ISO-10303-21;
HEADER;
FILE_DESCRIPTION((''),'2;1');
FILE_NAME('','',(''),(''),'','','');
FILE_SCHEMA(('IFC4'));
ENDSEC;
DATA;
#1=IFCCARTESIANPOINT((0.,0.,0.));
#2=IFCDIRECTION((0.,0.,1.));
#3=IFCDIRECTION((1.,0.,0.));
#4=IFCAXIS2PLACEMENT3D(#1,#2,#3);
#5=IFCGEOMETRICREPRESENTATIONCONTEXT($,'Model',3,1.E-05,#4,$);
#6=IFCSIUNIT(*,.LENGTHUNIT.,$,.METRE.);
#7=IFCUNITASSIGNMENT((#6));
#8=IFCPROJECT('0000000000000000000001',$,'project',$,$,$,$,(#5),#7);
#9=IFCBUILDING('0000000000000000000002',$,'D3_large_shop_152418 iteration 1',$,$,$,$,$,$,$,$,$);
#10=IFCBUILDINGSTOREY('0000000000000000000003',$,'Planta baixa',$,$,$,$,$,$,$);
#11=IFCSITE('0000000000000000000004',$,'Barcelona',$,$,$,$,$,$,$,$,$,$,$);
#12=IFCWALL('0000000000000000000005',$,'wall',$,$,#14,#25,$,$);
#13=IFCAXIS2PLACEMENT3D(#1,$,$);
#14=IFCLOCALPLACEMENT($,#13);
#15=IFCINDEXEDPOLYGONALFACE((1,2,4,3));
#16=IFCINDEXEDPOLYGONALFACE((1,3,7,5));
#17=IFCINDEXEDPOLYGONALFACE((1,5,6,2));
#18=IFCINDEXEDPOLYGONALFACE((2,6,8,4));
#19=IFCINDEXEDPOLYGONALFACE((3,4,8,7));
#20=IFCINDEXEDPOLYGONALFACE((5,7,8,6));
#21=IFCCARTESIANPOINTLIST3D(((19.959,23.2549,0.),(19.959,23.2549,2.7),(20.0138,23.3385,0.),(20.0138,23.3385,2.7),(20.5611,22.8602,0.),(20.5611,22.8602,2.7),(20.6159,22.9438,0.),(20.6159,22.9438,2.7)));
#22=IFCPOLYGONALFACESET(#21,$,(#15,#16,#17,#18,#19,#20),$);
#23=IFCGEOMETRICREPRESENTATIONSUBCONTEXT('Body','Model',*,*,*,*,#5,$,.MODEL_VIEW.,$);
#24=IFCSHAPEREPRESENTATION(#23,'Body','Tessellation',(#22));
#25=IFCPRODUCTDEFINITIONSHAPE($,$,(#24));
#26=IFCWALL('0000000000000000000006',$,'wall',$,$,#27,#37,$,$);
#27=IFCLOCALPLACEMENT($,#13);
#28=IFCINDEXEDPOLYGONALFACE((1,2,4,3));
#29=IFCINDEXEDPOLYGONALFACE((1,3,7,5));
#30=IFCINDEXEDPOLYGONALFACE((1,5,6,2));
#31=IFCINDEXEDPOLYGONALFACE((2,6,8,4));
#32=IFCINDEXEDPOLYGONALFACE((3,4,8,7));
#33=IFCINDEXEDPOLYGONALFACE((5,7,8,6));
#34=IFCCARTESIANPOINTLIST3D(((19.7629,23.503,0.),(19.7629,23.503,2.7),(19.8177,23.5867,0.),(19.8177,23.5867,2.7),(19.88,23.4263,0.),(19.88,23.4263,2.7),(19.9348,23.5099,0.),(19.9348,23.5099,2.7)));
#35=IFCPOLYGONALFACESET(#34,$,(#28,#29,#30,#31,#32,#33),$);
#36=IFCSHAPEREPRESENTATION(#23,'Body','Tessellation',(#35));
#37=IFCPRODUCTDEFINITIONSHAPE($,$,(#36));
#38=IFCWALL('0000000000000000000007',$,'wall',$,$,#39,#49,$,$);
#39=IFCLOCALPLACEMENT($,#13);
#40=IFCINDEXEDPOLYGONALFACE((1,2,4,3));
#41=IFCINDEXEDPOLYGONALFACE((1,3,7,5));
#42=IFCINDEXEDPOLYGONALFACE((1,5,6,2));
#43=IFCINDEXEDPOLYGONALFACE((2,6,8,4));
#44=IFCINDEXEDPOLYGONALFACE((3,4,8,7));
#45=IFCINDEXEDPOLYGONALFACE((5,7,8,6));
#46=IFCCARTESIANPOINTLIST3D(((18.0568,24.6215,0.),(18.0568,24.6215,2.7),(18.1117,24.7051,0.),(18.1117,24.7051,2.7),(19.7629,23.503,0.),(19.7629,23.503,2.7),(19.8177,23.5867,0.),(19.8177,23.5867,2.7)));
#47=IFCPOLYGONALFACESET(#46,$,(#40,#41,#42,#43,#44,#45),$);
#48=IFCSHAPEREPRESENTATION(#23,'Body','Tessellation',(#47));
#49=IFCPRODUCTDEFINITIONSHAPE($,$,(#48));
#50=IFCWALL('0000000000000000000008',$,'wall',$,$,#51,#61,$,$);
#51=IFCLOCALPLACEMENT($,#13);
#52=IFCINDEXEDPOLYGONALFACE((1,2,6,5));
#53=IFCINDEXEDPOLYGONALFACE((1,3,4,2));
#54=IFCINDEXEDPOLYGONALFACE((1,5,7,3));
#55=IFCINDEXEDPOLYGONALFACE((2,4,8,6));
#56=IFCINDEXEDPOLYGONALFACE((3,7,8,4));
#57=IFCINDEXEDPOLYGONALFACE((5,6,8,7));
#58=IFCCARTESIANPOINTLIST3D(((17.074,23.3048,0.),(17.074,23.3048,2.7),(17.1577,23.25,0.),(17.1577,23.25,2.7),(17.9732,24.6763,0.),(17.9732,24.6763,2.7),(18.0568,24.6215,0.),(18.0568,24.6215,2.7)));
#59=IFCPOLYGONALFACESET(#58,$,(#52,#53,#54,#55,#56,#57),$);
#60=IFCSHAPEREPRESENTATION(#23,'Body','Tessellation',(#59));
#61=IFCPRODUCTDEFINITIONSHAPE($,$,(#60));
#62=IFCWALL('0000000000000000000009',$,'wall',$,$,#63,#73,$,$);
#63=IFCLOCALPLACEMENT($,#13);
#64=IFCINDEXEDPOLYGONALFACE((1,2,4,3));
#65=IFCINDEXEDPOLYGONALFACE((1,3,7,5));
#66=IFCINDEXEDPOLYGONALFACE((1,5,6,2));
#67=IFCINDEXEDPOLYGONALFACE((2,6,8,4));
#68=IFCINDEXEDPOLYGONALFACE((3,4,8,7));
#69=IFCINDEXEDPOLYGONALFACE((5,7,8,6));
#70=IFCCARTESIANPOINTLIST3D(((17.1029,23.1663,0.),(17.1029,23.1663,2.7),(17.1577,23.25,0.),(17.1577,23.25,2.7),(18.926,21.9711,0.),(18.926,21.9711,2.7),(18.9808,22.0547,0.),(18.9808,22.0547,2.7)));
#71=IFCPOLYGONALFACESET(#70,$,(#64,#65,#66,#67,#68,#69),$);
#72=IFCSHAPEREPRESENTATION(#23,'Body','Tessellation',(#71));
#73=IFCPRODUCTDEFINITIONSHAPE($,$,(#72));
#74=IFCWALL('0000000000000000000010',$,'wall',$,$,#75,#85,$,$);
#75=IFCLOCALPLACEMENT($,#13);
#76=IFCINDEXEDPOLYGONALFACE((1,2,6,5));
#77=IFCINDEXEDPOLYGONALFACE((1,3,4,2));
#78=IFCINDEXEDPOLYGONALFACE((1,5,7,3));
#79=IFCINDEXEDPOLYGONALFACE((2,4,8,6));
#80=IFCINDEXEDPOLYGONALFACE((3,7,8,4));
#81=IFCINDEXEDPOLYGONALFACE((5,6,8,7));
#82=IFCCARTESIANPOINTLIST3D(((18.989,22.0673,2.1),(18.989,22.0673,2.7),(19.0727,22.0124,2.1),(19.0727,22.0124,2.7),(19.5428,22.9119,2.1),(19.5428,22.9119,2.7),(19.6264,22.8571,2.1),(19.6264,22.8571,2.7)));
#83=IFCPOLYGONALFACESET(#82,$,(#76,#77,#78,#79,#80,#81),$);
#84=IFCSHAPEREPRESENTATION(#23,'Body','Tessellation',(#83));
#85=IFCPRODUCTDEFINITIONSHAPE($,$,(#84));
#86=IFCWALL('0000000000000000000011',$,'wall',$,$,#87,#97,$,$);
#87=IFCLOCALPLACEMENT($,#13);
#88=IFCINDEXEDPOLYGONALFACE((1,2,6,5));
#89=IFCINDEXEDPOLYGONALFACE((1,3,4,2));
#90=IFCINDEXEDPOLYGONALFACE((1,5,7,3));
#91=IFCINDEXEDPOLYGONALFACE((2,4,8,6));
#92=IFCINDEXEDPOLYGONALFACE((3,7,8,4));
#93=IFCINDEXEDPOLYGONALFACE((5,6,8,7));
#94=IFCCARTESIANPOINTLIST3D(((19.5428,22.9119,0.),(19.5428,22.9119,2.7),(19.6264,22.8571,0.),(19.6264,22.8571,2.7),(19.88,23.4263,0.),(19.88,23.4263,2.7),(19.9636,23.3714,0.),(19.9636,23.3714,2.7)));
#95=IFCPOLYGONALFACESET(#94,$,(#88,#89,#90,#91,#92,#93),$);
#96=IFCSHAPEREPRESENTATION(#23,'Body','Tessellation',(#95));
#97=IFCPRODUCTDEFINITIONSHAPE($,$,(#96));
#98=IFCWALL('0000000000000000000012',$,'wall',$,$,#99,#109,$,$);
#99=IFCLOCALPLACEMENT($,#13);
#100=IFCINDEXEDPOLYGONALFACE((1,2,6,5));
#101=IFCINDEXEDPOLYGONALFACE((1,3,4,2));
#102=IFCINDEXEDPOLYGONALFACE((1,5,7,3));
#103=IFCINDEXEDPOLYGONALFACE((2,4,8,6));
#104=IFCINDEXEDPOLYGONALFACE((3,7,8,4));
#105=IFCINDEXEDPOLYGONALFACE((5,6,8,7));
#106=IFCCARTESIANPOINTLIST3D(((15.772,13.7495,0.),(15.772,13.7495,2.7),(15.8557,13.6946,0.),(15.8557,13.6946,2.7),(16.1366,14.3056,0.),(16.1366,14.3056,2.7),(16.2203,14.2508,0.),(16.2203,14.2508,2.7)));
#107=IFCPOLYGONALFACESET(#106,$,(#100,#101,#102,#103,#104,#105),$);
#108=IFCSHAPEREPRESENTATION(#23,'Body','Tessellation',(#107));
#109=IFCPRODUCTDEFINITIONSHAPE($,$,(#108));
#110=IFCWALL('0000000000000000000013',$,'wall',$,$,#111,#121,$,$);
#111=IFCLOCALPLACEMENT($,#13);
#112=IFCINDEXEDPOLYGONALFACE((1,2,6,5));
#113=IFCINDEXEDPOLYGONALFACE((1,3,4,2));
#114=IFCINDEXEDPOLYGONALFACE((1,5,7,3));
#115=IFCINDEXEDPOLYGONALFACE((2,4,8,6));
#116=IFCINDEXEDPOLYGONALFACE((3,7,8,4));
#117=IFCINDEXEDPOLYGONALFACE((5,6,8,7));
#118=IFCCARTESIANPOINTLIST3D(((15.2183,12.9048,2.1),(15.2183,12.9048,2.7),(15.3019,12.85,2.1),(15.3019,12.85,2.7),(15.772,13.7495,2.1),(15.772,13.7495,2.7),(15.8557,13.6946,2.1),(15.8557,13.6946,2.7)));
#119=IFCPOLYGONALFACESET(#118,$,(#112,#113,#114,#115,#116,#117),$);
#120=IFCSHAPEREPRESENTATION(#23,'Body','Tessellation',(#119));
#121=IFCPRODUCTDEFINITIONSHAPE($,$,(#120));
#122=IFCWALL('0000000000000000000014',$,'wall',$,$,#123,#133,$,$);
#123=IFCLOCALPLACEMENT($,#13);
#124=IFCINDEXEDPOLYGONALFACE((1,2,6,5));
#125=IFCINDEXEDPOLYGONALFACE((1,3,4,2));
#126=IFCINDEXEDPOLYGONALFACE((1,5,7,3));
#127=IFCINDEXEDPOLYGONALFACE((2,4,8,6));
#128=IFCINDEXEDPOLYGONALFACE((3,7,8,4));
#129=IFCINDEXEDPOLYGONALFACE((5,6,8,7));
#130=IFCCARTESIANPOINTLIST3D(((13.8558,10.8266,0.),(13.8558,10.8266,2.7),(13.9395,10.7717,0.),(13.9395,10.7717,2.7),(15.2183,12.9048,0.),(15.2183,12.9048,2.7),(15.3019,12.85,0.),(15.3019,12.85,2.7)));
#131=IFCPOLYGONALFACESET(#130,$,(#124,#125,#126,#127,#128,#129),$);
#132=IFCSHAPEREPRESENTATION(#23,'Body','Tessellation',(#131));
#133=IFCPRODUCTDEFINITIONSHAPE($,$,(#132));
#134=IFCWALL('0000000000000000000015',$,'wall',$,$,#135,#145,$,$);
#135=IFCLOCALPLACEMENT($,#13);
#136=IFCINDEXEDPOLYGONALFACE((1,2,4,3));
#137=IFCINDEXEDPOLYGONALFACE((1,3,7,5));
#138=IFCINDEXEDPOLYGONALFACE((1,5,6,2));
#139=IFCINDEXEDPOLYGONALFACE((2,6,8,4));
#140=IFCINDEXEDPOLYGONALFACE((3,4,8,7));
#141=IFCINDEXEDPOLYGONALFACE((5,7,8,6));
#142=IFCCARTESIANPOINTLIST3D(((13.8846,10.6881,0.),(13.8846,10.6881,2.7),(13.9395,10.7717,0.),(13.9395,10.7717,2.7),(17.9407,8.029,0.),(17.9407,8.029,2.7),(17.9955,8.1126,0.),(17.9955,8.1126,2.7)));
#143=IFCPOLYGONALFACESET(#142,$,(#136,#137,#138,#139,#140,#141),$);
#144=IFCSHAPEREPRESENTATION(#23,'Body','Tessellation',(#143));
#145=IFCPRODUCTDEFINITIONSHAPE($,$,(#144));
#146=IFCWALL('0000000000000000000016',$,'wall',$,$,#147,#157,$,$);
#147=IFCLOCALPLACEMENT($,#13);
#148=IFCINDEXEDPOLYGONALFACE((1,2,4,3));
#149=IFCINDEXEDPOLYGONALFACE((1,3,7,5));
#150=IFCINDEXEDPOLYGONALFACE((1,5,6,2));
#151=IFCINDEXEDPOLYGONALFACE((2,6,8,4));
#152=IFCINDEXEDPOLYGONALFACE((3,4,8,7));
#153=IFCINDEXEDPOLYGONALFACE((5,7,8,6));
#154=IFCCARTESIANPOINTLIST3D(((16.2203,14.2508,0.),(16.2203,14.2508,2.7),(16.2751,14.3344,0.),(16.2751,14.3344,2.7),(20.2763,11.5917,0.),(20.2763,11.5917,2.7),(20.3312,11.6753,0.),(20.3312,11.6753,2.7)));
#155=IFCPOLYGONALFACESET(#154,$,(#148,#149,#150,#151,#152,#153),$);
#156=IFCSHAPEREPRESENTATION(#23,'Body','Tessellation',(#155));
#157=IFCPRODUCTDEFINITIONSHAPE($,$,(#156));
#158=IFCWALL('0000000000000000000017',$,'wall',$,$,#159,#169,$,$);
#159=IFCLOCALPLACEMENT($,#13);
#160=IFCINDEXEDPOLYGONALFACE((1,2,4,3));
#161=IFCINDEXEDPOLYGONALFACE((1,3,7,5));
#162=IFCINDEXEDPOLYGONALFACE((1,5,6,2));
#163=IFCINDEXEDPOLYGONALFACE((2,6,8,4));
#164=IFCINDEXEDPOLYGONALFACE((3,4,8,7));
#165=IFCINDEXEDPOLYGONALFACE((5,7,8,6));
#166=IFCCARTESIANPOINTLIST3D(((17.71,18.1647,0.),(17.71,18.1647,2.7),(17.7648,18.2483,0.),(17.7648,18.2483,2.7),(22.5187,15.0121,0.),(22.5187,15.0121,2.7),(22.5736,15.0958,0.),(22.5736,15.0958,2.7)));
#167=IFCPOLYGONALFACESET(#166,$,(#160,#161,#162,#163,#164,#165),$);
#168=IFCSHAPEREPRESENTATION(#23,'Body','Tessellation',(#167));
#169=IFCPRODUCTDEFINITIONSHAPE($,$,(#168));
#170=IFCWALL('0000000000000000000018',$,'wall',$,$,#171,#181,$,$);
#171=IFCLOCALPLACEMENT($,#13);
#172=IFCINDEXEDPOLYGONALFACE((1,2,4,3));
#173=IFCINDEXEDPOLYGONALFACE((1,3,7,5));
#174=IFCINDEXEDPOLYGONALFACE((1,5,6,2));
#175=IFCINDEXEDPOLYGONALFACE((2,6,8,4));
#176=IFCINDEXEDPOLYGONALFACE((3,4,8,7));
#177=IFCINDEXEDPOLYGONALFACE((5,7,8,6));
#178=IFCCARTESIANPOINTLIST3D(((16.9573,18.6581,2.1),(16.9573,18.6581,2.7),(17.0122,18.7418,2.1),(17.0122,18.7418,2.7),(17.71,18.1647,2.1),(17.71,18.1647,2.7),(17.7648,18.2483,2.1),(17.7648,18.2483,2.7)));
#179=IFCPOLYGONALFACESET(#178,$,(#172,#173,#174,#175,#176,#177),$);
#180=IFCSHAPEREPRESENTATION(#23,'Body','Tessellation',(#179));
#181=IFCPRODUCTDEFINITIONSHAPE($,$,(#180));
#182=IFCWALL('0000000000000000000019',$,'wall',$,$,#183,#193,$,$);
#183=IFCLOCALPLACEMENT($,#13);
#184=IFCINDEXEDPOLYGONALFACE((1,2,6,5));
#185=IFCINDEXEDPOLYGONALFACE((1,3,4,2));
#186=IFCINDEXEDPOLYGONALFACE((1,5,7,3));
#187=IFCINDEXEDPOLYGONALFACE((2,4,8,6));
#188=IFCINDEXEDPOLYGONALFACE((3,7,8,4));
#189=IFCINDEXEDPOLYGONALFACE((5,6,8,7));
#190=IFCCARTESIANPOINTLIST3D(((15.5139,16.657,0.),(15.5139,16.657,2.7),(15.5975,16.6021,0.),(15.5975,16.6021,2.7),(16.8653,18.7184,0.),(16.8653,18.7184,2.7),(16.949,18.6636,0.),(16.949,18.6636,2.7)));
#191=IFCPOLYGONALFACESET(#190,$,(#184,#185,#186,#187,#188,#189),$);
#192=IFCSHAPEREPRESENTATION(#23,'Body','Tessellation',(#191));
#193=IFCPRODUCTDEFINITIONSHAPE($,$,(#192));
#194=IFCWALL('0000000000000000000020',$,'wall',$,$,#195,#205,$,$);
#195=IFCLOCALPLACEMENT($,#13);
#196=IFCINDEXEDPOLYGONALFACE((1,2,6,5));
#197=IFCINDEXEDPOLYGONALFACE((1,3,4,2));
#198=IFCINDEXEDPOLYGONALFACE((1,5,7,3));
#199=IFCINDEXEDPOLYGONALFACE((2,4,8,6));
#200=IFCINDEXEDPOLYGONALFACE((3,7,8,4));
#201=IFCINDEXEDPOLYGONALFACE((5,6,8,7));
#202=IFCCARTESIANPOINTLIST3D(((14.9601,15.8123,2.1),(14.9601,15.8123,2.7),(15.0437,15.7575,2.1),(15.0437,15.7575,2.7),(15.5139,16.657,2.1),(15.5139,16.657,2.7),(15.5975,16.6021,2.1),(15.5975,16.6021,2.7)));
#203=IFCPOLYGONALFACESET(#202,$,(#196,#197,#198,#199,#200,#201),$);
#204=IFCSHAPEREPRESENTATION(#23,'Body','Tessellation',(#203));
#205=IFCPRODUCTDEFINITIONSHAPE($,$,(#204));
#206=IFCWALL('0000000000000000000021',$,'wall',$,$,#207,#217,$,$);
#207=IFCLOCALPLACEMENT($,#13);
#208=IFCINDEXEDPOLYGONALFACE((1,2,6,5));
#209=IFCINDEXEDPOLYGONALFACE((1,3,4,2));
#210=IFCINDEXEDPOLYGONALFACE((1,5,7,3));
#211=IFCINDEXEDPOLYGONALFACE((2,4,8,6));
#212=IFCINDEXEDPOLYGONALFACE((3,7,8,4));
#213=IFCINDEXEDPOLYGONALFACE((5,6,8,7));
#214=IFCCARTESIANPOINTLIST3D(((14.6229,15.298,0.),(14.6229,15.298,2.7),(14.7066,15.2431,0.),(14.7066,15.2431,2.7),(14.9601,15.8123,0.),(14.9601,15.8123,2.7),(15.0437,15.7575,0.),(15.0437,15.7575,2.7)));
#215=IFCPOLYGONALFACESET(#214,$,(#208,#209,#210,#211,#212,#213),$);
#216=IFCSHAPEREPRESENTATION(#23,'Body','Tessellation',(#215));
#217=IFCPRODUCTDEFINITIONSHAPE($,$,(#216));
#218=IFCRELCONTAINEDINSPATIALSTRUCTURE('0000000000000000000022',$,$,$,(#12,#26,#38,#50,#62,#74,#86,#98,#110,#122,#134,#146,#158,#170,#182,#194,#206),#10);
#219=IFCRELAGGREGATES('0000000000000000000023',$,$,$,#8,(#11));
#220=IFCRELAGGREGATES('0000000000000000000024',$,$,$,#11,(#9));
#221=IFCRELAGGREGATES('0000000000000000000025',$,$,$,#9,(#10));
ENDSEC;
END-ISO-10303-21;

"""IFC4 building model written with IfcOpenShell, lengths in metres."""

from ifc_helpers import new_model, si_unit, frame, origin, origin_with_axes, place, context, subcontext, project, spatial, polyline, outline, extrude, element, save


model = new_model("IFC4")

# Units and contexts
model_context = context("Model", 3, precision=1e-05, world=origin_with_axes())
body_context = subcontext(model_context, "Body", "Model", "MODEL_VIEW")
ifc_project = project(units=[si_unit("LENGTHUNIT", "METRE")], contexts=[model_context])

# Site, building, storey
site = spatial("IfcSite", under=ifc_project, Name="Barcelona")
building = spatial("IfcBuilding", under=site, Name="D3_large_shop_152418 iteration 1")
storey = spatial("IfcBuildingStorey", under=building, Name="Planta baixa")

# Walls
wall_1_placement = place(None, origin_with_axes())
element("IfcWall", 1, at=wall_1_placement, inside=storey, Name="wall", context=body_context, shape_type="SweptSolid", body=[
    extrude(outline(polyline([(20.0138, 23.3385), (20.6159, 22.9438), (20.5611, 22.8602), (19.959, 23.2549), (20.0138, 23.3385)])), origin(), (0.0, 0.0, 1.0), 2.7),
])
wall_2_placement = place(None, origin_with_axes())
element("IfcWall", 2, at=wall_2_placement, inside=storey, Name="wall", context=body_context, shape_type="SweptSolid", body=[
    extrude(outline(polyline([(19.88, 23.4263), (19.7629, 23.503), (19.8177, 23.5867), (19.9348, 23.5099), (19.88, 23.4263)])), origin(), (0.0, 0.0, 1.0), 2.7),
])
wall_3_placement = place(None, origin_with_axes())
element("IfcWall", 3, at=wall_3_placement, inside=storey, Name="wall", context=body_context, shape_type="SweptSolid", body=[
    extrude(outline(polyline([(19.7629, 23.503), (18.0568, 24.6215), (18.1117, 24.7051), (19.8177, 23.5867), (19.7629, 23.503)])), origin(), (0.0, 0.0, 1.0), 2.7),
])
wall_4_placement = place(None, origin_with_axes())
element("IfcWall", 4, at=wall_4_placement, inside=storey, Name="wall", context=body_context, shape_type="SweptSolid", body=[
    extrude(outline(polyline([(18.0568, 24.6215), (17.1577, 23.25), (17.074, 23.3048), (17.9732, 24.6763), (18.0568, 24.6215)])), origin(), (0.0, 0.0, 1.0), 2.7),
])
wall_5_placement = place(None, origin_with_axes())
element("IfcWall", 5, at=wall_5_placement, inside=storey, Name="wall", context=body_context, shape_type="SweptSolid", body=[
    extrude(outline(polyline([(17.1577, 23.25), (18.9808, 22.0547), (18.926, 21.9711), (17.1029, 23.1663), (17.1577, 23.25)])), origin(), (0.0, 0.0, 1.0), 2.7),
])
wall_6_placement = place(None, origin_with_axes())
element("IfcWall", 6, at=wall_6_placement, inside=storey, Name="wall", context=body_context, shape_type="SweptSolid", body=[
    extrude(outline(polyline([(18.989, 22.0673), (19.5428, 22.9119), (19.6264, 22.8571), (19.0727, 22.0124), (18.989, 22.0673)])), frame((0.0, 0.0, 2.1)), (0.0, 0.0, 1.0), 0.6),
])
wall_7_placement = place(None, origin_with_axes())
element("IfcWall", 7, at=wall_7_placement, inside=storey, Name="wall", context=body_context, shape_type="SweptSolid", body=[
    extrude(outline(polyline([(19.5428, 22.9119), (19.88, 23.4263), (19.9636, 23.3714), (19.6264, 22.8571), (19.5428, 22.9119)])), origin(), (0.0, 0.0, 1.0), 2.7),
])
wall_8_placement = place(None, origin_with_axes())
element("IfcWall", 8, at=wall_8_placement, inside=storey, Name="wall", context=body_context, shape_type="SweptSolid", body=[
    extrude(outline(polyline([(16.2203, 14.2508), (15.8557, 13.6946), (15.772, 13.7495), (16.1366, 14.3056), (16.2203, 14.2508)])), origin(), (0.0, 0.0, 1.0), 2.7),
])
wall_9_placement = place(None, origin_with_axes())
element("IfcWall", 9, at=wall_9_placement, inside=storey, Name="wall", context=body_context, shape_type="SweptSolid", body=[
    extrude(outline(polyline([(15.8557, 13.6946), (15.3019, 12.85), (15.2183, 12.9048), (15.772, 13.7495), (15.8557, 13.6946)])), frame((0.0, 0.0, 2.1)), (0.0, 0.0, 1.0), 0.6),
])
wall_10_placement = place(None, origin_with_axes())
element("IfcWall", 10, at=wall_10_placement, inside=storey, Name="wall", context=body_context, shape_type="SweptSolid", body=[
    extrude(outline(polyline([(15.3019, 12.85), (13.9395, 10.7717), (13.8558, 10.8266), (15.2183, 12.9048), (15.3019, 12.85)])), origin(), (0.0, 0.0, 1.0), 2.7),
])
wall_11_placement = place(None, origin_with_axes())
element("IfcWall", 11, at=wall_11_placement, inside=storey, Name="wall", context=body_context, shape_type="SweptSolid", body=[
    extrude(outline(polyline([(13.9395, 10.7717), (17.9955, 8.1126), (17.9407, 8.029), (13.8846, 10.6881), (13.9395, 10.7717)])), origin(), (0.0, 0.0, 1.0), 2.7),
])
wall_12_placement = place(None, origin_with_axes())
element("IfcWall", 12, at=wall_12_placement, inside=storey, Name="wall", context=body_context, shape_type="SweptSolid", body=[
    extrude(outline(polyline([(20.2763, 11.5917), (16.2203, 14.2508), (16.2751, 14.3344), (20.3312, 11.6753), (20.2763, 11.5917)])), origin(), (0.0, 0.0, 1.0), 2.7),
])
wall_13_placement = place(None, origin_with_axes())
element("IfcWall", 13, at=wall_13_placement, inside=storey, Name="wall", context=body_context, shape_type="SweptSolid", body=[
    extrude(outline(polyline([(22.5187, 15.0121), (17.71, 18.1647), (17.7648, 18.2483), (22.5736, 15.0958), (22.5187, 15.0121)])), origin(), (0.0, 0.0, 1.0), 2.7),
])
wall_14_placement = place(None, origin_with_axes())
element("IfcWall", 14, at=wall_14_placement, inside=storey, Name="wall", context=body_context, shape_type="SweptSolid", body=[
    extrude(outline(polyline([(17.71, 18.1647), (16.9573, 18.6581), (17.0122, 18.7418), (17.7648, 18.2483), (17.71, 18.1647)])), frame((0.0, 0.0, 2.1)), (0.0, 0.0, 1.0), 0.6),
])
wall_15_placement = place(None, origin_with_axes())
element("IfcWall", 15, at=wall_15_placement, inside=storey, Name="wall", context=body_context, shape_type="SweptSolid", body=[
    extrude(outline(polyline([(16.949, 18.6636), (15.5975, 16.6021), (15.5139, 16.657), (16.8653, 18.7184), (16.949, 18.6636)])), origin(), (0.0, 0.0, 1.0), 2.7),
])
wall_16_placement = place(None, origin_with_axes())
element("IfcWall", 16, at=wall_16_placement, inside=storey, Name="wall", context=body_context, shape_type="SweptSolid", body=[
    extrude(outline(polyline([(15.5975, 16.6021), (15.0437, 15.7575), (14.9601, 15.8123), (15.5139, 16.657), (15.5975, 16.6021)])), frame((0.0, 0.0, 2.1)), (0.0, 0.0, 1.0), 0.6),
])
wall_17_placement = place(None, origin_with_axes())
element("IfcWall", 17, at=wall_17_placement, inside=storey, Name="wall", context=body_context, shape_type="SweptSolid", body=[
    extrude(outline(polyline([(15.0437, 15.7575), (14.7066, 15.2431), (14.6229, 15.298), (14.9601, 15.8123), (15.0437, 15.7575)])), origin(), (0.0, 0.0, 1.0), 2.7),
])

save(model, "model.ifc")
